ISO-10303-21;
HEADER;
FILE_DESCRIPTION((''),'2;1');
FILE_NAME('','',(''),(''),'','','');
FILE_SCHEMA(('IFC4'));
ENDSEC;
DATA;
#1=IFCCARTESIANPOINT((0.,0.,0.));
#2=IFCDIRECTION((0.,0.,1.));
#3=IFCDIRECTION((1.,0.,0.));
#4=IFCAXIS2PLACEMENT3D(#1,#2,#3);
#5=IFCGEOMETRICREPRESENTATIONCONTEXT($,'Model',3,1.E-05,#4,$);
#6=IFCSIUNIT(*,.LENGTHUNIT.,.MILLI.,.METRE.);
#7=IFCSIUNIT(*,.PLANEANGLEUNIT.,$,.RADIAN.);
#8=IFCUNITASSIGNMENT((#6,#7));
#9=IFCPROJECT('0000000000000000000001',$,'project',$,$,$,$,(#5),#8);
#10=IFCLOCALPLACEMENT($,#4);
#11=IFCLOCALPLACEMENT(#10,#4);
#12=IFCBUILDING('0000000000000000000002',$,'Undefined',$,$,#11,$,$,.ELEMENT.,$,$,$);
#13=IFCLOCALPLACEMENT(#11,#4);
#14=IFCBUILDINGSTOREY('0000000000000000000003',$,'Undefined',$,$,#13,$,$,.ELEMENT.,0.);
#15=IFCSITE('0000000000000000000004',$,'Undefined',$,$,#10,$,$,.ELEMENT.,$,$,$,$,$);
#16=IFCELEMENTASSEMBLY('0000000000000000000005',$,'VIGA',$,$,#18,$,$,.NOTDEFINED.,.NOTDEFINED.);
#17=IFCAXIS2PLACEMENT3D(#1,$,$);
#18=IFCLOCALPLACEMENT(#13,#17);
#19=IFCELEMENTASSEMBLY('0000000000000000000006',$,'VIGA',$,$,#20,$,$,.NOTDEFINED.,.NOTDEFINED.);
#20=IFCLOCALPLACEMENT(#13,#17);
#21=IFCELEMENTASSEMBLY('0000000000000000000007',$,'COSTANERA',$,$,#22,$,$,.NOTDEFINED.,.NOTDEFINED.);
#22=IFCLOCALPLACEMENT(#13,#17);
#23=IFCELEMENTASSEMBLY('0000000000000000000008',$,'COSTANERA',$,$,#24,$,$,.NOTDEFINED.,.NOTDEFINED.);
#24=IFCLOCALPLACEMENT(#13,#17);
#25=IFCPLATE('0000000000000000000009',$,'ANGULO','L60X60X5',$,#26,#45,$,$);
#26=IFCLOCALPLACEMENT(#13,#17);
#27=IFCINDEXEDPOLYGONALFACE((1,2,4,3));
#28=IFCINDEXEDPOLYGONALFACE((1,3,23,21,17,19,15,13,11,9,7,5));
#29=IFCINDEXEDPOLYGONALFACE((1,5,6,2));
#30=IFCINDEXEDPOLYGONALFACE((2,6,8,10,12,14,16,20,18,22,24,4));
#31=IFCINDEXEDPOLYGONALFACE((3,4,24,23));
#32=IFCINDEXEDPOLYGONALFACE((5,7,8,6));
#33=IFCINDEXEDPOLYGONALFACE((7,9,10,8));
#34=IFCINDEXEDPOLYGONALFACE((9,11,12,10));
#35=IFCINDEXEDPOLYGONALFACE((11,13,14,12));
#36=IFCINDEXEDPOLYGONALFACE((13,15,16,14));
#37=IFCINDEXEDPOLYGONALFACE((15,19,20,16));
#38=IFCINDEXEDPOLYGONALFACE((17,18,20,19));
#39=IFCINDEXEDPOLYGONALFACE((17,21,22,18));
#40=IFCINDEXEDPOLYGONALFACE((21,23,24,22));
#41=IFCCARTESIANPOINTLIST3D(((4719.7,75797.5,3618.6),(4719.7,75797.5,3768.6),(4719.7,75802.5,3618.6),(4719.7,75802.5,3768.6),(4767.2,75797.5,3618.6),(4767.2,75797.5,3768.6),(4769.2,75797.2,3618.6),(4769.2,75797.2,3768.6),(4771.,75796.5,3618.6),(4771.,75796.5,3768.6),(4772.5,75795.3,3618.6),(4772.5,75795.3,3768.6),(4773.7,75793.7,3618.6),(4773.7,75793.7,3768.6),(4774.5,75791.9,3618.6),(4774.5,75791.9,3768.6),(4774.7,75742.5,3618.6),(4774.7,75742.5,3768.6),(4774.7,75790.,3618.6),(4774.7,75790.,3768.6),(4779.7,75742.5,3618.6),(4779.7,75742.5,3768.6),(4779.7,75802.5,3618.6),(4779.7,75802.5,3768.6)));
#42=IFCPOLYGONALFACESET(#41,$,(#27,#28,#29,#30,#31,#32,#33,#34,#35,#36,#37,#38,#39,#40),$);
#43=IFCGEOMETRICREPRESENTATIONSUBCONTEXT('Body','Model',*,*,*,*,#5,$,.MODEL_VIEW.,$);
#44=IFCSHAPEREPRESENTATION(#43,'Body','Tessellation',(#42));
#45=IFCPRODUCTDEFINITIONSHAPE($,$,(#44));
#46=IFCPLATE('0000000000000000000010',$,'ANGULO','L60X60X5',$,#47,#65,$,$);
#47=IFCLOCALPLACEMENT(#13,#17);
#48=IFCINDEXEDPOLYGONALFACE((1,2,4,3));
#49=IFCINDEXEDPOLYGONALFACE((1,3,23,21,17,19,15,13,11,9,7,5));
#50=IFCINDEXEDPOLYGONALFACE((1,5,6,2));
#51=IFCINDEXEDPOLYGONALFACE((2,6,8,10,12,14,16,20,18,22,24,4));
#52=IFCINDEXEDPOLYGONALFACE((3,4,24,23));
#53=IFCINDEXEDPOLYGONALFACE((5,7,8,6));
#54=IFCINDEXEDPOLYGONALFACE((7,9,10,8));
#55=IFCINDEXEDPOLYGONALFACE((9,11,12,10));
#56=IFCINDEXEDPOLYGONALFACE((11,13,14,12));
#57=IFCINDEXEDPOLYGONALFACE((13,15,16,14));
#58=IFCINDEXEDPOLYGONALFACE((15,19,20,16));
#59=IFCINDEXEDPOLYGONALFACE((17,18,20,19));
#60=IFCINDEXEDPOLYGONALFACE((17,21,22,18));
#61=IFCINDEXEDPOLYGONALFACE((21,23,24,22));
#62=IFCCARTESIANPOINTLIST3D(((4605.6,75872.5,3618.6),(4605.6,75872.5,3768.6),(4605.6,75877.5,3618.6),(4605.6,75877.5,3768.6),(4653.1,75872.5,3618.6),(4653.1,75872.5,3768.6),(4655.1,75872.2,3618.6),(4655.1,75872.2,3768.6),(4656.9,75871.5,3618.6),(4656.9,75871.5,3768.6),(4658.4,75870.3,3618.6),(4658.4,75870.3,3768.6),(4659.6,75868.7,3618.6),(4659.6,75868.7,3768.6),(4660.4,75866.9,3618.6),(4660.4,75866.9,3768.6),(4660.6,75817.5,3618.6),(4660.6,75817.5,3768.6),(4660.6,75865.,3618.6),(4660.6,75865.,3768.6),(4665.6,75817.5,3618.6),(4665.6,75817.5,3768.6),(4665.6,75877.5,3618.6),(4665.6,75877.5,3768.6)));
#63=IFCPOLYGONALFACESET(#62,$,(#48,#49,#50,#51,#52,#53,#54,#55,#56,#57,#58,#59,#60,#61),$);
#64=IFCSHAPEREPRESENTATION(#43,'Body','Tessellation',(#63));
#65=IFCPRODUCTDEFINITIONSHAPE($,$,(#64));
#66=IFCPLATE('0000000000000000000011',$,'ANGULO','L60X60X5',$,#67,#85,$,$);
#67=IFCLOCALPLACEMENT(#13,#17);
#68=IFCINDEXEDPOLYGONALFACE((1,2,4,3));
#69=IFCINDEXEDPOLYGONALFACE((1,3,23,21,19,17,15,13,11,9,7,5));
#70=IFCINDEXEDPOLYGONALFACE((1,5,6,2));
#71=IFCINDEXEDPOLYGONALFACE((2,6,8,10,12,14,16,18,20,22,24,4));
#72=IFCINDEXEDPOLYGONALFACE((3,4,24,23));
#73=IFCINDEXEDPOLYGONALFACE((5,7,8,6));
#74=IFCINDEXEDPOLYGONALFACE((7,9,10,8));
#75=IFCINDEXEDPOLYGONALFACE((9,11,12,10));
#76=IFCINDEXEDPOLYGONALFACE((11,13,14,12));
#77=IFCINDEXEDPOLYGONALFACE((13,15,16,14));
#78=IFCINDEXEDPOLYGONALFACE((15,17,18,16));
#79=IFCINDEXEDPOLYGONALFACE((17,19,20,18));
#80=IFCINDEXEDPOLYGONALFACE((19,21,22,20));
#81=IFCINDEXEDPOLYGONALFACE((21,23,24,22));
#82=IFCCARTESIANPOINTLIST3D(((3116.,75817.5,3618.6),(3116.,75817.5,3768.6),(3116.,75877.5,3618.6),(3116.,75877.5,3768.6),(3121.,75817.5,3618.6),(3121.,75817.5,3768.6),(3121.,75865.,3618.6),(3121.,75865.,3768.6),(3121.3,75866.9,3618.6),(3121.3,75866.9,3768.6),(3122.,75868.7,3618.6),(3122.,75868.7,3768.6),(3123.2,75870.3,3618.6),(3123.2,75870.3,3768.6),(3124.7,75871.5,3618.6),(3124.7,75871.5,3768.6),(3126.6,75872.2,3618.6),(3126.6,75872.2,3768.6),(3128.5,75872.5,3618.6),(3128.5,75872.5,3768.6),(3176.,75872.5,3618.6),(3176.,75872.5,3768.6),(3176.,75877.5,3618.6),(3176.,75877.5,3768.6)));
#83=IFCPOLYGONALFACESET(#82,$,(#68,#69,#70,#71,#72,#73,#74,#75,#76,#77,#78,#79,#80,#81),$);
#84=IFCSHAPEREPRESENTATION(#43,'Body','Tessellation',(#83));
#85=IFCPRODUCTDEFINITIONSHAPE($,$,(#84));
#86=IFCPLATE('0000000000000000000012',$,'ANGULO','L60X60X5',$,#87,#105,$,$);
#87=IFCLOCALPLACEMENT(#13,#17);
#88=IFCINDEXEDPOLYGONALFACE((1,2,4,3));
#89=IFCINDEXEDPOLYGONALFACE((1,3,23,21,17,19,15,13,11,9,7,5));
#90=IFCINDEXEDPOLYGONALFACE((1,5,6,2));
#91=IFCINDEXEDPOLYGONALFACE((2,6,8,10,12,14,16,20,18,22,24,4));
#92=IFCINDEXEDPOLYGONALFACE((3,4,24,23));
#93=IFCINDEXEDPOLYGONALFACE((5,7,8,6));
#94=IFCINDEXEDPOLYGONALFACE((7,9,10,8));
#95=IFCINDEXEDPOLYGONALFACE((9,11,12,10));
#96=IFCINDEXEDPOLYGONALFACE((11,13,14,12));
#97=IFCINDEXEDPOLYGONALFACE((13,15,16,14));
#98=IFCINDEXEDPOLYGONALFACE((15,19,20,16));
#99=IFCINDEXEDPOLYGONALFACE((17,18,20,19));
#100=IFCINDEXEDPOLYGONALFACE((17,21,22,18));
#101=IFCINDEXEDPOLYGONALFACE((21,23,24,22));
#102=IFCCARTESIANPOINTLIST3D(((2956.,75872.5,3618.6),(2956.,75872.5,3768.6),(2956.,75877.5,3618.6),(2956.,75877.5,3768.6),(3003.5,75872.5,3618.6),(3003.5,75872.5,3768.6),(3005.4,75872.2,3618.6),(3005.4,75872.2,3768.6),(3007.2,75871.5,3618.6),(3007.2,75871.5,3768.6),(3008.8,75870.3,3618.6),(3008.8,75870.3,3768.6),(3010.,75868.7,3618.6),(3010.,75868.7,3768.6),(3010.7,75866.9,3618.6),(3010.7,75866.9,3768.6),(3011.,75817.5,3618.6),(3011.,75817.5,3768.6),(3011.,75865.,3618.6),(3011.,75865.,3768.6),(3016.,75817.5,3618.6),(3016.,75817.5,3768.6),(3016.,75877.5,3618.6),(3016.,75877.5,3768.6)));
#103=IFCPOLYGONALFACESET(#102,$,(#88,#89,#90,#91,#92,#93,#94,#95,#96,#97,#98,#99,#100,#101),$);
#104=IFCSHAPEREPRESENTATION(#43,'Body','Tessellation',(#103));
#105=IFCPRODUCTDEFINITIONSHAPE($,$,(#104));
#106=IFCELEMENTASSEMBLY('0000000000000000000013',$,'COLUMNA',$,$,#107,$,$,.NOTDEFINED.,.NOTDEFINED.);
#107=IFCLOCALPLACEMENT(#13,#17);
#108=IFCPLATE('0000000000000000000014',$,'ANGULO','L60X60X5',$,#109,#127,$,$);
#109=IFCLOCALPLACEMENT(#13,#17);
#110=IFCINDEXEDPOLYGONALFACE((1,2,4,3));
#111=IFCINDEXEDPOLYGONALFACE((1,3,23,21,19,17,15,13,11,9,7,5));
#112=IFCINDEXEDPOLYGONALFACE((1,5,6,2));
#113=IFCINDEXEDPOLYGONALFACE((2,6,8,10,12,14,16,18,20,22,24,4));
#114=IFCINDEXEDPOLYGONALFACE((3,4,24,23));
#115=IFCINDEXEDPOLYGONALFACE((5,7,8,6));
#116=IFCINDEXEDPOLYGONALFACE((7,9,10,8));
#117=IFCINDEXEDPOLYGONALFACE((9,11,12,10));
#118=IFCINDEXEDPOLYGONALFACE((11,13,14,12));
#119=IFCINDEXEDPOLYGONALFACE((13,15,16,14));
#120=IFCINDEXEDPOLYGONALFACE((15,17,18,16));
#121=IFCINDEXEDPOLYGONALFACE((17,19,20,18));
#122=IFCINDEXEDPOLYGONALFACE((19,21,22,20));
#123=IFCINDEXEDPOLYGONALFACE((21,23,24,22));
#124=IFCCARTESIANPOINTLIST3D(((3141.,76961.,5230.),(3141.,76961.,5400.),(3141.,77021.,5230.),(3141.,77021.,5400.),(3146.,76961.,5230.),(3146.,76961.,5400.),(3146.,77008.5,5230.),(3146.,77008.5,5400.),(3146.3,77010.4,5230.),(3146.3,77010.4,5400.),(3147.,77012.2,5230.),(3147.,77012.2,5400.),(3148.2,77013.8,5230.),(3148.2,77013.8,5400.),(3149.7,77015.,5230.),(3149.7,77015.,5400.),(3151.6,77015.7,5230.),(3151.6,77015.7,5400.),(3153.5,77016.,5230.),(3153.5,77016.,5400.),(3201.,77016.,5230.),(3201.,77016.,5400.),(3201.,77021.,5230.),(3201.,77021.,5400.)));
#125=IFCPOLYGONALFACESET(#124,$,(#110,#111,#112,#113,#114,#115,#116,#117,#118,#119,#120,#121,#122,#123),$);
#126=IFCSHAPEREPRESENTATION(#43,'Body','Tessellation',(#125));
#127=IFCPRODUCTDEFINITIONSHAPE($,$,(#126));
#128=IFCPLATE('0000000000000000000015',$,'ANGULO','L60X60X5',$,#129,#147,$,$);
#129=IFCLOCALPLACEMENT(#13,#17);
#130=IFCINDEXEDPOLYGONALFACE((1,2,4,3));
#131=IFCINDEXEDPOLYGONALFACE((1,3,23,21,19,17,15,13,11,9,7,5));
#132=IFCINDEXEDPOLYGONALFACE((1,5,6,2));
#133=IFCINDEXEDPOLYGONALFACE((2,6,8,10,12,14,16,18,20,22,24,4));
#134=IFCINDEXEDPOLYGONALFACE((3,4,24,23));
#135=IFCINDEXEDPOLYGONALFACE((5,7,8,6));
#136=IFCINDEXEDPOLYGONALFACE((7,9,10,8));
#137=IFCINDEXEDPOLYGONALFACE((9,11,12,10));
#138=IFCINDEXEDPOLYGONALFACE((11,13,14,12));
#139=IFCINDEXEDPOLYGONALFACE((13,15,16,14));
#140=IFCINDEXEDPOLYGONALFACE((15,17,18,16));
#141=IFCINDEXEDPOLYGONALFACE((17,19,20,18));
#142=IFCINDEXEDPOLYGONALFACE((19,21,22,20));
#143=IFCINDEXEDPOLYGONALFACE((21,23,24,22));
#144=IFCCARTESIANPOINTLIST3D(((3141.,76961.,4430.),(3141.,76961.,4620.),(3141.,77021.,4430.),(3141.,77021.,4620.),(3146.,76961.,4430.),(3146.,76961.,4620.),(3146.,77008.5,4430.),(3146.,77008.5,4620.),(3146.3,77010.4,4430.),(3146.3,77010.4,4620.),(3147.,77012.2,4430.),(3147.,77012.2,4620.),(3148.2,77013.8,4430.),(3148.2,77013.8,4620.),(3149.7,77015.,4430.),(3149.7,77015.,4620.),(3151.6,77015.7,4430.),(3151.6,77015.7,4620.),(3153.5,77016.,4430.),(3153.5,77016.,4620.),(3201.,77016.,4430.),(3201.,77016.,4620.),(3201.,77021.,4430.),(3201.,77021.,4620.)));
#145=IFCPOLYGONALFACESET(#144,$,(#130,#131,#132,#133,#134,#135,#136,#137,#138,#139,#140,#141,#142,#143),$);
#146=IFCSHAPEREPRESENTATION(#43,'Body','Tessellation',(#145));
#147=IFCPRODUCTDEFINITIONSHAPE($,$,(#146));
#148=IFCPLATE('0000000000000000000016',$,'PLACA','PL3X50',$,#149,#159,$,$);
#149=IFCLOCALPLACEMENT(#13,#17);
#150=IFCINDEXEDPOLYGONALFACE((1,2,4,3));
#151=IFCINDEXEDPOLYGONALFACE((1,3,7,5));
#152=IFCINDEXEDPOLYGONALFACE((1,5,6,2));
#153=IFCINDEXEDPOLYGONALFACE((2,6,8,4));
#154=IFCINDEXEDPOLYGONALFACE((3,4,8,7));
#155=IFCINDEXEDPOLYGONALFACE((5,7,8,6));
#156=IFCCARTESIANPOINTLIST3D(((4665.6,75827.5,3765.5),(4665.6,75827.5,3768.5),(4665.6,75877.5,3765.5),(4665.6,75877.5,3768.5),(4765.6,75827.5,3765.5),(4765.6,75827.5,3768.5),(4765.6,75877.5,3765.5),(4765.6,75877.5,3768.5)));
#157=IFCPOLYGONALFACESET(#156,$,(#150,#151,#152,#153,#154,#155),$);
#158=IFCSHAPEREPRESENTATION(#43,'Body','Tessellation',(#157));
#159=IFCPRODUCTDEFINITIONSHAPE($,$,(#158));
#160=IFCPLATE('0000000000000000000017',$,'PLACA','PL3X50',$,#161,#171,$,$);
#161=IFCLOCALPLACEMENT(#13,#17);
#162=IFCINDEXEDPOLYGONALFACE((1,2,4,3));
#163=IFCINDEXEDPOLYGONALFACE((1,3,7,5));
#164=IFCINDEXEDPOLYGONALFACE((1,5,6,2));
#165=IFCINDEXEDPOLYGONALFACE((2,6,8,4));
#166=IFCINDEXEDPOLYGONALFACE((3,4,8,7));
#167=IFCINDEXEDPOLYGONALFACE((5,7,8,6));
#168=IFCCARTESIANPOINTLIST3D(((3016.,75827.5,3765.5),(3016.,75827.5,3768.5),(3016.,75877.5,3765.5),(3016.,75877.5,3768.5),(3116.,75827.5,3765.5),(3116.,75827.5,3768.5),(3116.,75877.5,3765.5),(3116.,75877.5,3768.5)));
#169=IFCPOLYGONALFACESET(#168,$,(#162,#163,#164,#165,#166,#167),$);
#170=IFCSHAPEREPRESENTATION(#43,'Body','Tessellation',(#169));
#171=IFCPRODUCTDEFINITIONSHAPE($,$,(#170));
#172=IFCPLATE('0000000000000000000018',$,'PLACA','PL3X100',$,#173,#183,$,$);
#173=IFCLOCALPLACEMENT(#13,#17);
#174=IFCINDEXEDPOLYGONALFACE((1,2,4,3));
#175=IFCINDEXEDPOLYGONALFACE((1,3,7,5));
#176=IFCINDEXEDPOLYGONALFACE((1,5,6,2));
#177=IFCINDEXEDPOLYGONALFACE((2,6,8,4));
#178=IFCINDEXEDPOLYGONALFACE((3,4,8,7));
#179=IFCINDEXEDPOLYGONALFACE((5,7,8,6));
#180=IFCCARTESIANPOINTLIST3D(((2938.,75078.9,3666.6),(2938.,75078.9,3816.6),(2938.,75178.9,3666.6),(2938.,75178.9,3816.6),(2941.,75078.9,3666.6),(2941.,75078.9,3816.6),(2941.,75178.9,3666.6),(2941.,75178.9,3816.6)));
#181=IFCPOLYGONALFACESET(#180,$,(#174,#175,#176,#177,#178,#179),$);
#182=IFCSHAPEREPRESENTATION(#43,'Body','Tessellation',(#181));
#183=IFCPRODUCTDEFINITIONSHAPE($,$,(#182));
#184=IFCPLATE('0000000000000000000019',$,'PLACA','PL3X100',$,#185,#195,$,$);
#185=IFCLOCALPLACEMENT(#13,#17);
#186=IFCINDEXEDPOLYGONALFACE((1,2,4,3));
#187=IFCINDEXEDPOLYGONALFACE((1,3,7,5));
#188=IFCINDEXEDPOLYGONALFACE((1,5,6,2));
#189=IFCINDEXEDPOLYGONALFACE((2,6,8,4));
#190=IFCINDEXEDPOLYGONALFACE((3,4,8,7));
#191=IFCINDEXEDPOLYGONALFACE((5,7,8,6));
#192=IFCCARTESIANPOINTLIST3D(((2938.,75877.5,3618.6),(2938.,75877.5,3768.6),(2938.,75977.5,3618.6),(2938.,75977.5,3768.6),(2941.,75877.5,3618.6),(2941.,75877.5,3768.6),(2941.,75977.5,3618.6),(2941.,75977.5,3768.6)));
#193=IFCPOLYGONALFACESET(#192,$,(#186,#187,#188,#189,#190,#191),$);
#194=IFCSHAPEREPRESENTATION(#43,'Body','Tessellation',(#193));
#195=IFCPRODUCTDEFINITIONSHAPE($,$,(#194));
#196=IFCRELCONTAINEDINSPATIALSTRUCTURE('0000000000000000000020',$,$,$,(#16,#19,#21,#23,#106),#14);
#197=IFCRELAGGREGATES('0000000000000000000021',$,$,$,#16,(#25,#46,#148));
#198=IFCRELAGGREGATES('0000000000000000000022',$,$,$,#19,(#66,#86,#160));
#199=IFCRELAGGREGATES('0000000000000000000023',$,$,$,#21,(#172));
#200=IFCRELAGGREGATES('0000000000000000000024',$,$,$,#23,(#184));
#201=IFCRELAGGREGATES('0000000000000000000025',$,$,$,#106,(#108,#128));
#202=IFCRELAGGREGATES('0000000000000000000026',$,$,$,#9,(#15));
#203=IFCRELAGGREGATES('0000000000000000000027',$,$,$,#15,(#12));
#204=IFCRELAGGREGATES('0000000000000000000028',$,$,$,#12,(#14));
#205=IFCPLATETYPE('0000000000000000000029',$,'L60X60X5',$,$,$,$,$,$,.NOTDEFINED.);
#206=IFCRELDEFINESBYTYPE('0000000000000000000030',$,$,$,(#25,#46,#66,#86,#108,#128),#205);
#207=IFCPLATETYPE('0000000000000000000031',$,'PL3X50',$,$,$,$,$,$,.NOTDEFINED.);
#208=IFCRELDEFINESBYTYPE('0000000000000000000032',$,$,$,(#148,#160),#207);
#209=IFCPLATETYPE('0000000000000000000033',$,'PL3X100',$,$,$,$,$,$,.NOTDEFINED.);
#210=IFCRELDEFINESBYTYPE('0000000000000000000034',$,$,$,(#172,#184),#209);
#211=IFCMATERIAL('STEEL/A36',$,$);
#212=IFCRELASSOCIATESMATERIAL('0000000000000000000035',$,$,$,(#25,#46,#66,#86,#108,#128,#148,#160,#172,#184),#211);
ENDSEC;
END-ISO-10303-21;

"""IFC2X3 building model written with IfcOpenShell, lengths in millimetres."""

from ifc_helpers import new_model, si_unit, frame, origin_with_axes, origin_2d_with_axis, place, context, subcontext, project, spatial, polyline, l_section, outline, extrude, material, type_object, element, aggregate, save


model = new_model("IFC2X3")

# Units and contexts
model_context = context("Model", 3, precision=1e-05, world=origin_with_axes())
body_context = subcontext(model_context, "Body", "Model", "MODEL_VIEW")
ifc_project = project(units=[si_unit("LENGTHUNIT", "METRE", prefix="MILLI"), si_unit("PLANEANGLEUNIT", "RADIAN")], contexts=[model_context])

# Site, building, storey
site_placement = place(None, origin_with_axes())
site = spatial("IfcSite", under=ifc_project, at=site_placement, Name="Undefined", CompositionType="ELEMENT")
building_placement = place(site_placement, origin_with_axes())
building = spatial("IfcBuilding", under=site, at=building_placement, Name="Undefined", CompositionType="ELEMENT")
storey_placement = place(building_placement, origin_with_axes())
storey = spatial("IfcBuildingStorey", under=building, at=storey_placement, Name="Undefined", CompositionType="ELEMENT", Elevation=0.0)

# Element assemblies
assembly_1_placement = place(storey_placement, origin_with_axes())
assembly_1 = element("IfcElementAssembly", 1, at=assembly_1_placement, inside=storey, Name="VIGA", AssemblyPlace="NOTDEFINED", PredefinedType="NOTDEFINED")
ifc_material_1 = material(Name="STEEL/A36")
assembly_2_placement = place(storey_placement, origin_with_axes())
assembly_2 = element("IfcElementAssembly", 2, at=assembly_2_placement, inside=storey, Name="VIGA", AssemblyPlace="NOTDEFINED", PredefinedType="NOTDEFINED")
assembly_3_placement = place(storey_placement, origin_with_axes())
assembly_3 = element("IfcElementAssembly", 3, at=assembly_3_placement, inside=storey, Name="COSTANERA", AssemblyPlace="NOTDEFINED", PredefinedType="NOTDEFINED")
assembly_4_placement = place(storey_placement, origin_with_axes())
assembly_4 = element("IfcElementAssembly", 4, at=assembly_4_placement, inside=storey, Name="COSTANERA", AssemblyPlace="NOTDEFINED", PredefinedType="NOTDEFINED")

# Plates
plate_type_1 = type_object("IfcPlateType", Name="L60X60X5", PredefinedType="NOTDEFINED")
plate_1_placement = place(assembly_1_placement, frame((4749.7, 75772.5, 3618.6), z_axis=(-1.0, 0.0, 0.0), x_axis=(0.0, 0.0, 1.0)))
plate_1 = element("IfcPlate", 5, at=plate_1_placement, type_object=plate_type_1, material=ifc_material_1, Name="ANGULO", Description="L60X60X5", context=body_context, shape_type="SweptSolid", body=[
    extrude(l_section(Depth=60.0, Width=60.0, Thickness=5.0, FilletRadius=7.5, at=origin_2d_with_axis()), frame((150.0, 0.0, 0.0), z_axis=(-1.0, 0.0, 0.0), x_axis=(0.0, -1.0, 0.0)), (0.0, 0.0, 1.0), 150.0),
])
plate_2_placement = place(assembly_1_placement, frame((4635.6, 75847.5, 3768.6), z_axis=(0.0, -1.0, 0.0), x_axis=(0.0, 0.0, -1.0)))
plate_2 = element("IfcPlate", 6, at=plate_2_placement, type_object=plate_type_1, material=ifc_material_1, Name="ANGULO", Description="L60X60X5", context=body_context, shape_type="SweptSolid", body=[
    extrude(l_section(Depth=60.0, Width=60.0, Thickness=5.0, FilletRadius=7.5, at=origin_2d_with_axis()), frame((150.0, 0.0, 0.0), z_axis=(-1.0, 0.0, 0.0), x_axis=(0.0, -1.0, 0.0)), (0.0, 0.0, 1.0), 150.0),
])
plate_3_placement = place(assembly_2_placement, frame((3146.0, 75847.5, 3618.6), z_axis=(0.0, -1.0, 0.0), x_axis=(0.0, 0.0, 1.0)))
plate_3 = element("IfcPlate", 7, at=plate_3_placement, type_object=plate_type_1, material=ifc_material_1, Name="ANGULO", Description="L60X60X5", context=body_context, shape_type="SweptSolid", body=[
    extrude(l_section(Depth=60.0, Width=60.0, Thickness=5.0, FilletRadius=7.5, at=origin_2d_with_axis()), frame((150.0, 0.0, 0.0), z_axis=(-1.0, 0.0, 0.0), x_axis=(0.0, -1.0, 0.0)), (0.0, 0.0, 1.0), 150.0),
])
plate_4_placement = place(assembly_2_placement, frame((2986.0, 75847.5, 3768.6), z_axis=(0.0, -1.0, 0.0), x_axis=(0.0, 0.0, -1.0)))
plate_4 = element("IfcPlate", 8, at=plate_4_placement, type_object=plate_type_1, material=ifc_material_1, Name="ANGULO", Description="L60X60X5", context=body_context, shape_type="SweptSolid", body=[
    extrude(l_section(Depth=60.0, Width=60.0, Thickness=5.0, FilletRadius=7.5, at=origin_2d_with_axis()), frame((150.0, 0.0, 0.0), z_axis=(-1.0, 0.0, 0.0), x_axis=(0.0, -1.0, 0.0)), (0.0, 0.0, 1.0), 150.0),
])

# Element assembly, plates
assembly_5_placement = place(storey_placement, origin_with_axes())
assembly_5 = element("IfcElementAssembly", 9, at=assembly_5_placement, inside=storey, Name="COLUMNA", AssemblyPlace="NOTDEFINED", PredefinedType="NOTDEFINED")
plate_5_placement = place(assembly_5_placement, frame((3171.0, 76991.0, 5230.0), z_axis=(0.0, -1.0, 0.0), x_axis=(0.0, 0.0, 1.0)))
plate_5 = element("IfcPlate", 10, at=plate_5_placement, type_object=plate_type_1, material=ifc_material_1, Name="ANGULO", Description="L60X60X5", context=body_context, shape_type="SweptSolid", body=[
    extrude(l_section(Depth=60.0, Width=60.0, Thickness=5.0, FilletRadius=7.5, at=origin_2d_with_axis()), frame((170.0, 0.0, 0.0), z_axis=(-1.0, 0.0, 0.0), x_axis=(0.0, -1.0, 0.0)), (0.0, 0.0, 1.0), 170.0),
])
plate_6_placement = place(assembly_5_placement, frame((3171.0, 76991.0, 4430.0), z_axis=(0.0, -1.0, 0.0), x_axis=(0.0, 0.0, 1.0)))
plate_6 = element("IfcPlate", 11, at=plate_6_placement, type_object=plate_type_1, material=ifc_material_1, Name="ANGULO", Description="L60X60X5", context=body_context, shape_type="SweptSolid", body=[
    extrude(l_section(Depth=60.0, Width=60.0, Thickness=5.0, FilletRadius=7.5, at=origin_2d_with_axis()), frame((190.0, 0.0, 0.0), z_axis=(-1.0, 0.0, 0.0), x_axis=(0.0, -1.0, 0.0)), (0.0, 0.0, 1.0), 190.0),
])

# Plates
plate_type_2 = type_object("IfcPlateType", Name="PL3X50", PredefinedType="NOTDEFINED")
plate_7_placement = place(assembly_1_placement, frame((4665.6, 75827.5, 3767.0), z_axis=(0.0, 0.0, -1.0), x_axis=(0.0, 1.0, 0.0)))
plate_7 = element("IfcPlate", 12, at=plate_7_placement, type_object=plate_type_2, material=ifc_material_1, Name="PLACA", Description="PL3X50", context=body_context, shape_type="SweptSolid", body=[
    extrude(outline(polyline([(0.0, 0.0), (50.0, 0.0), (50.0, 100.0), (0.0, 100.0), (0.0, 0.0)])), frame((0.0, 0.0, -1.5), z_axis=(0.0, 0.0, 1.0), x_axis=(1.0, 0.0, 0.0)), (0.0, 0.0, 1.0), 3.0),
])
aggregate(assembly_1, [plate_1, plate_2, plate_7])
plate_8_placement = place(assembly_2_placement, frame((3016.0, 75827.5, 3767.0), z_axis=(0.0, 0.0, -1.0), x_axis=(0.0, 1.0, 0.0)))
plate_8 = element("IfcPlate", 13, at=plate_8_placement, type_object=plate_type_2, material=ifc_material_1, Name="PLACA", Description="PL3X50", context=body_context, shape_type="SweptSolid", body=[
    extrude(outline(polyline([(0.0, 0.0), (50.0, 0.0), (50.0, 100.0), (0.0, 100.0), (0.0, 0.0)])), frame((0.0, 0.0, -1.5), z_axis=(0.0, 0.0, 1.0), x_axis=(1.0, 0.0, 0.0)), (0.0, 0.0, 1.0), 3.0),
])
aggregate(assembly_2, [plate_3, plate_4, plate_8])
plate_type_3 = type_object("IfcPlateType", Name="PL3X100", PredefinedType="NOTDEFINED")
plate_9_placement = place(assembly_3_placement, frame((2939.5, 75078.9, 3666.6), z_axis=(1.0, 0.0, 0.0), x_axis=(0.0, 1.0, 0.0)))
plate_9 = element("IfcPlate", 14, at=plate_9_placement, type_object=plate_type_3, material=ifc_material_1, Name="PLACA", Description="PL3X100", context=body_context, shape_type="SweptSolid", body=[
    extrude(outline(polyline([(0.0, 0.0), (100.0, 0.0), (100.0, 150.0), (0.0, 150.0), (0.0, 0.0)])), frame((0.0, 0.0, -1.5), z_axis=(0.0, 0.0, 1.0), x_axis=(1.0, 0.0, 0.0)), (0.0, 0.0, 1.0), 3.0),
])
plate_10_placement = place(assembly_4_placement, frame((2939.5, 75877.5, 3618.6), z_axis=(1.0, 0.0, 0.0), x_axis=(0.0, 1.0, 0.0)))
plate_10 = element("IfcPlate", 15, at=plate_10_placement, type_object=plate_type_3, material=ifc_material_1, Name="PLACA", Description="PL3X100", context=body_context, shape_type="SweptSolid", body=[
    extrude(outline(polyline([(0.0, 0.0), (100.0, 0.0), (100.0, 150.0), (0.0, 150.0), (0.0, 0.0)])), frame((0.0, 0.0, -1.5), z_axis=(0.0, 0.0, 1.0), x_axis=(1.0, 0.0, 0.0)), (0.0, 0.0, 1.0), 3.0),
])

aggregate(assembly_3, [plate_9])
aggregate(assembly_4, [plate_10])
aggregate(assembly_5, [plate_5, plate_6])

save(model, "model.ifc")
